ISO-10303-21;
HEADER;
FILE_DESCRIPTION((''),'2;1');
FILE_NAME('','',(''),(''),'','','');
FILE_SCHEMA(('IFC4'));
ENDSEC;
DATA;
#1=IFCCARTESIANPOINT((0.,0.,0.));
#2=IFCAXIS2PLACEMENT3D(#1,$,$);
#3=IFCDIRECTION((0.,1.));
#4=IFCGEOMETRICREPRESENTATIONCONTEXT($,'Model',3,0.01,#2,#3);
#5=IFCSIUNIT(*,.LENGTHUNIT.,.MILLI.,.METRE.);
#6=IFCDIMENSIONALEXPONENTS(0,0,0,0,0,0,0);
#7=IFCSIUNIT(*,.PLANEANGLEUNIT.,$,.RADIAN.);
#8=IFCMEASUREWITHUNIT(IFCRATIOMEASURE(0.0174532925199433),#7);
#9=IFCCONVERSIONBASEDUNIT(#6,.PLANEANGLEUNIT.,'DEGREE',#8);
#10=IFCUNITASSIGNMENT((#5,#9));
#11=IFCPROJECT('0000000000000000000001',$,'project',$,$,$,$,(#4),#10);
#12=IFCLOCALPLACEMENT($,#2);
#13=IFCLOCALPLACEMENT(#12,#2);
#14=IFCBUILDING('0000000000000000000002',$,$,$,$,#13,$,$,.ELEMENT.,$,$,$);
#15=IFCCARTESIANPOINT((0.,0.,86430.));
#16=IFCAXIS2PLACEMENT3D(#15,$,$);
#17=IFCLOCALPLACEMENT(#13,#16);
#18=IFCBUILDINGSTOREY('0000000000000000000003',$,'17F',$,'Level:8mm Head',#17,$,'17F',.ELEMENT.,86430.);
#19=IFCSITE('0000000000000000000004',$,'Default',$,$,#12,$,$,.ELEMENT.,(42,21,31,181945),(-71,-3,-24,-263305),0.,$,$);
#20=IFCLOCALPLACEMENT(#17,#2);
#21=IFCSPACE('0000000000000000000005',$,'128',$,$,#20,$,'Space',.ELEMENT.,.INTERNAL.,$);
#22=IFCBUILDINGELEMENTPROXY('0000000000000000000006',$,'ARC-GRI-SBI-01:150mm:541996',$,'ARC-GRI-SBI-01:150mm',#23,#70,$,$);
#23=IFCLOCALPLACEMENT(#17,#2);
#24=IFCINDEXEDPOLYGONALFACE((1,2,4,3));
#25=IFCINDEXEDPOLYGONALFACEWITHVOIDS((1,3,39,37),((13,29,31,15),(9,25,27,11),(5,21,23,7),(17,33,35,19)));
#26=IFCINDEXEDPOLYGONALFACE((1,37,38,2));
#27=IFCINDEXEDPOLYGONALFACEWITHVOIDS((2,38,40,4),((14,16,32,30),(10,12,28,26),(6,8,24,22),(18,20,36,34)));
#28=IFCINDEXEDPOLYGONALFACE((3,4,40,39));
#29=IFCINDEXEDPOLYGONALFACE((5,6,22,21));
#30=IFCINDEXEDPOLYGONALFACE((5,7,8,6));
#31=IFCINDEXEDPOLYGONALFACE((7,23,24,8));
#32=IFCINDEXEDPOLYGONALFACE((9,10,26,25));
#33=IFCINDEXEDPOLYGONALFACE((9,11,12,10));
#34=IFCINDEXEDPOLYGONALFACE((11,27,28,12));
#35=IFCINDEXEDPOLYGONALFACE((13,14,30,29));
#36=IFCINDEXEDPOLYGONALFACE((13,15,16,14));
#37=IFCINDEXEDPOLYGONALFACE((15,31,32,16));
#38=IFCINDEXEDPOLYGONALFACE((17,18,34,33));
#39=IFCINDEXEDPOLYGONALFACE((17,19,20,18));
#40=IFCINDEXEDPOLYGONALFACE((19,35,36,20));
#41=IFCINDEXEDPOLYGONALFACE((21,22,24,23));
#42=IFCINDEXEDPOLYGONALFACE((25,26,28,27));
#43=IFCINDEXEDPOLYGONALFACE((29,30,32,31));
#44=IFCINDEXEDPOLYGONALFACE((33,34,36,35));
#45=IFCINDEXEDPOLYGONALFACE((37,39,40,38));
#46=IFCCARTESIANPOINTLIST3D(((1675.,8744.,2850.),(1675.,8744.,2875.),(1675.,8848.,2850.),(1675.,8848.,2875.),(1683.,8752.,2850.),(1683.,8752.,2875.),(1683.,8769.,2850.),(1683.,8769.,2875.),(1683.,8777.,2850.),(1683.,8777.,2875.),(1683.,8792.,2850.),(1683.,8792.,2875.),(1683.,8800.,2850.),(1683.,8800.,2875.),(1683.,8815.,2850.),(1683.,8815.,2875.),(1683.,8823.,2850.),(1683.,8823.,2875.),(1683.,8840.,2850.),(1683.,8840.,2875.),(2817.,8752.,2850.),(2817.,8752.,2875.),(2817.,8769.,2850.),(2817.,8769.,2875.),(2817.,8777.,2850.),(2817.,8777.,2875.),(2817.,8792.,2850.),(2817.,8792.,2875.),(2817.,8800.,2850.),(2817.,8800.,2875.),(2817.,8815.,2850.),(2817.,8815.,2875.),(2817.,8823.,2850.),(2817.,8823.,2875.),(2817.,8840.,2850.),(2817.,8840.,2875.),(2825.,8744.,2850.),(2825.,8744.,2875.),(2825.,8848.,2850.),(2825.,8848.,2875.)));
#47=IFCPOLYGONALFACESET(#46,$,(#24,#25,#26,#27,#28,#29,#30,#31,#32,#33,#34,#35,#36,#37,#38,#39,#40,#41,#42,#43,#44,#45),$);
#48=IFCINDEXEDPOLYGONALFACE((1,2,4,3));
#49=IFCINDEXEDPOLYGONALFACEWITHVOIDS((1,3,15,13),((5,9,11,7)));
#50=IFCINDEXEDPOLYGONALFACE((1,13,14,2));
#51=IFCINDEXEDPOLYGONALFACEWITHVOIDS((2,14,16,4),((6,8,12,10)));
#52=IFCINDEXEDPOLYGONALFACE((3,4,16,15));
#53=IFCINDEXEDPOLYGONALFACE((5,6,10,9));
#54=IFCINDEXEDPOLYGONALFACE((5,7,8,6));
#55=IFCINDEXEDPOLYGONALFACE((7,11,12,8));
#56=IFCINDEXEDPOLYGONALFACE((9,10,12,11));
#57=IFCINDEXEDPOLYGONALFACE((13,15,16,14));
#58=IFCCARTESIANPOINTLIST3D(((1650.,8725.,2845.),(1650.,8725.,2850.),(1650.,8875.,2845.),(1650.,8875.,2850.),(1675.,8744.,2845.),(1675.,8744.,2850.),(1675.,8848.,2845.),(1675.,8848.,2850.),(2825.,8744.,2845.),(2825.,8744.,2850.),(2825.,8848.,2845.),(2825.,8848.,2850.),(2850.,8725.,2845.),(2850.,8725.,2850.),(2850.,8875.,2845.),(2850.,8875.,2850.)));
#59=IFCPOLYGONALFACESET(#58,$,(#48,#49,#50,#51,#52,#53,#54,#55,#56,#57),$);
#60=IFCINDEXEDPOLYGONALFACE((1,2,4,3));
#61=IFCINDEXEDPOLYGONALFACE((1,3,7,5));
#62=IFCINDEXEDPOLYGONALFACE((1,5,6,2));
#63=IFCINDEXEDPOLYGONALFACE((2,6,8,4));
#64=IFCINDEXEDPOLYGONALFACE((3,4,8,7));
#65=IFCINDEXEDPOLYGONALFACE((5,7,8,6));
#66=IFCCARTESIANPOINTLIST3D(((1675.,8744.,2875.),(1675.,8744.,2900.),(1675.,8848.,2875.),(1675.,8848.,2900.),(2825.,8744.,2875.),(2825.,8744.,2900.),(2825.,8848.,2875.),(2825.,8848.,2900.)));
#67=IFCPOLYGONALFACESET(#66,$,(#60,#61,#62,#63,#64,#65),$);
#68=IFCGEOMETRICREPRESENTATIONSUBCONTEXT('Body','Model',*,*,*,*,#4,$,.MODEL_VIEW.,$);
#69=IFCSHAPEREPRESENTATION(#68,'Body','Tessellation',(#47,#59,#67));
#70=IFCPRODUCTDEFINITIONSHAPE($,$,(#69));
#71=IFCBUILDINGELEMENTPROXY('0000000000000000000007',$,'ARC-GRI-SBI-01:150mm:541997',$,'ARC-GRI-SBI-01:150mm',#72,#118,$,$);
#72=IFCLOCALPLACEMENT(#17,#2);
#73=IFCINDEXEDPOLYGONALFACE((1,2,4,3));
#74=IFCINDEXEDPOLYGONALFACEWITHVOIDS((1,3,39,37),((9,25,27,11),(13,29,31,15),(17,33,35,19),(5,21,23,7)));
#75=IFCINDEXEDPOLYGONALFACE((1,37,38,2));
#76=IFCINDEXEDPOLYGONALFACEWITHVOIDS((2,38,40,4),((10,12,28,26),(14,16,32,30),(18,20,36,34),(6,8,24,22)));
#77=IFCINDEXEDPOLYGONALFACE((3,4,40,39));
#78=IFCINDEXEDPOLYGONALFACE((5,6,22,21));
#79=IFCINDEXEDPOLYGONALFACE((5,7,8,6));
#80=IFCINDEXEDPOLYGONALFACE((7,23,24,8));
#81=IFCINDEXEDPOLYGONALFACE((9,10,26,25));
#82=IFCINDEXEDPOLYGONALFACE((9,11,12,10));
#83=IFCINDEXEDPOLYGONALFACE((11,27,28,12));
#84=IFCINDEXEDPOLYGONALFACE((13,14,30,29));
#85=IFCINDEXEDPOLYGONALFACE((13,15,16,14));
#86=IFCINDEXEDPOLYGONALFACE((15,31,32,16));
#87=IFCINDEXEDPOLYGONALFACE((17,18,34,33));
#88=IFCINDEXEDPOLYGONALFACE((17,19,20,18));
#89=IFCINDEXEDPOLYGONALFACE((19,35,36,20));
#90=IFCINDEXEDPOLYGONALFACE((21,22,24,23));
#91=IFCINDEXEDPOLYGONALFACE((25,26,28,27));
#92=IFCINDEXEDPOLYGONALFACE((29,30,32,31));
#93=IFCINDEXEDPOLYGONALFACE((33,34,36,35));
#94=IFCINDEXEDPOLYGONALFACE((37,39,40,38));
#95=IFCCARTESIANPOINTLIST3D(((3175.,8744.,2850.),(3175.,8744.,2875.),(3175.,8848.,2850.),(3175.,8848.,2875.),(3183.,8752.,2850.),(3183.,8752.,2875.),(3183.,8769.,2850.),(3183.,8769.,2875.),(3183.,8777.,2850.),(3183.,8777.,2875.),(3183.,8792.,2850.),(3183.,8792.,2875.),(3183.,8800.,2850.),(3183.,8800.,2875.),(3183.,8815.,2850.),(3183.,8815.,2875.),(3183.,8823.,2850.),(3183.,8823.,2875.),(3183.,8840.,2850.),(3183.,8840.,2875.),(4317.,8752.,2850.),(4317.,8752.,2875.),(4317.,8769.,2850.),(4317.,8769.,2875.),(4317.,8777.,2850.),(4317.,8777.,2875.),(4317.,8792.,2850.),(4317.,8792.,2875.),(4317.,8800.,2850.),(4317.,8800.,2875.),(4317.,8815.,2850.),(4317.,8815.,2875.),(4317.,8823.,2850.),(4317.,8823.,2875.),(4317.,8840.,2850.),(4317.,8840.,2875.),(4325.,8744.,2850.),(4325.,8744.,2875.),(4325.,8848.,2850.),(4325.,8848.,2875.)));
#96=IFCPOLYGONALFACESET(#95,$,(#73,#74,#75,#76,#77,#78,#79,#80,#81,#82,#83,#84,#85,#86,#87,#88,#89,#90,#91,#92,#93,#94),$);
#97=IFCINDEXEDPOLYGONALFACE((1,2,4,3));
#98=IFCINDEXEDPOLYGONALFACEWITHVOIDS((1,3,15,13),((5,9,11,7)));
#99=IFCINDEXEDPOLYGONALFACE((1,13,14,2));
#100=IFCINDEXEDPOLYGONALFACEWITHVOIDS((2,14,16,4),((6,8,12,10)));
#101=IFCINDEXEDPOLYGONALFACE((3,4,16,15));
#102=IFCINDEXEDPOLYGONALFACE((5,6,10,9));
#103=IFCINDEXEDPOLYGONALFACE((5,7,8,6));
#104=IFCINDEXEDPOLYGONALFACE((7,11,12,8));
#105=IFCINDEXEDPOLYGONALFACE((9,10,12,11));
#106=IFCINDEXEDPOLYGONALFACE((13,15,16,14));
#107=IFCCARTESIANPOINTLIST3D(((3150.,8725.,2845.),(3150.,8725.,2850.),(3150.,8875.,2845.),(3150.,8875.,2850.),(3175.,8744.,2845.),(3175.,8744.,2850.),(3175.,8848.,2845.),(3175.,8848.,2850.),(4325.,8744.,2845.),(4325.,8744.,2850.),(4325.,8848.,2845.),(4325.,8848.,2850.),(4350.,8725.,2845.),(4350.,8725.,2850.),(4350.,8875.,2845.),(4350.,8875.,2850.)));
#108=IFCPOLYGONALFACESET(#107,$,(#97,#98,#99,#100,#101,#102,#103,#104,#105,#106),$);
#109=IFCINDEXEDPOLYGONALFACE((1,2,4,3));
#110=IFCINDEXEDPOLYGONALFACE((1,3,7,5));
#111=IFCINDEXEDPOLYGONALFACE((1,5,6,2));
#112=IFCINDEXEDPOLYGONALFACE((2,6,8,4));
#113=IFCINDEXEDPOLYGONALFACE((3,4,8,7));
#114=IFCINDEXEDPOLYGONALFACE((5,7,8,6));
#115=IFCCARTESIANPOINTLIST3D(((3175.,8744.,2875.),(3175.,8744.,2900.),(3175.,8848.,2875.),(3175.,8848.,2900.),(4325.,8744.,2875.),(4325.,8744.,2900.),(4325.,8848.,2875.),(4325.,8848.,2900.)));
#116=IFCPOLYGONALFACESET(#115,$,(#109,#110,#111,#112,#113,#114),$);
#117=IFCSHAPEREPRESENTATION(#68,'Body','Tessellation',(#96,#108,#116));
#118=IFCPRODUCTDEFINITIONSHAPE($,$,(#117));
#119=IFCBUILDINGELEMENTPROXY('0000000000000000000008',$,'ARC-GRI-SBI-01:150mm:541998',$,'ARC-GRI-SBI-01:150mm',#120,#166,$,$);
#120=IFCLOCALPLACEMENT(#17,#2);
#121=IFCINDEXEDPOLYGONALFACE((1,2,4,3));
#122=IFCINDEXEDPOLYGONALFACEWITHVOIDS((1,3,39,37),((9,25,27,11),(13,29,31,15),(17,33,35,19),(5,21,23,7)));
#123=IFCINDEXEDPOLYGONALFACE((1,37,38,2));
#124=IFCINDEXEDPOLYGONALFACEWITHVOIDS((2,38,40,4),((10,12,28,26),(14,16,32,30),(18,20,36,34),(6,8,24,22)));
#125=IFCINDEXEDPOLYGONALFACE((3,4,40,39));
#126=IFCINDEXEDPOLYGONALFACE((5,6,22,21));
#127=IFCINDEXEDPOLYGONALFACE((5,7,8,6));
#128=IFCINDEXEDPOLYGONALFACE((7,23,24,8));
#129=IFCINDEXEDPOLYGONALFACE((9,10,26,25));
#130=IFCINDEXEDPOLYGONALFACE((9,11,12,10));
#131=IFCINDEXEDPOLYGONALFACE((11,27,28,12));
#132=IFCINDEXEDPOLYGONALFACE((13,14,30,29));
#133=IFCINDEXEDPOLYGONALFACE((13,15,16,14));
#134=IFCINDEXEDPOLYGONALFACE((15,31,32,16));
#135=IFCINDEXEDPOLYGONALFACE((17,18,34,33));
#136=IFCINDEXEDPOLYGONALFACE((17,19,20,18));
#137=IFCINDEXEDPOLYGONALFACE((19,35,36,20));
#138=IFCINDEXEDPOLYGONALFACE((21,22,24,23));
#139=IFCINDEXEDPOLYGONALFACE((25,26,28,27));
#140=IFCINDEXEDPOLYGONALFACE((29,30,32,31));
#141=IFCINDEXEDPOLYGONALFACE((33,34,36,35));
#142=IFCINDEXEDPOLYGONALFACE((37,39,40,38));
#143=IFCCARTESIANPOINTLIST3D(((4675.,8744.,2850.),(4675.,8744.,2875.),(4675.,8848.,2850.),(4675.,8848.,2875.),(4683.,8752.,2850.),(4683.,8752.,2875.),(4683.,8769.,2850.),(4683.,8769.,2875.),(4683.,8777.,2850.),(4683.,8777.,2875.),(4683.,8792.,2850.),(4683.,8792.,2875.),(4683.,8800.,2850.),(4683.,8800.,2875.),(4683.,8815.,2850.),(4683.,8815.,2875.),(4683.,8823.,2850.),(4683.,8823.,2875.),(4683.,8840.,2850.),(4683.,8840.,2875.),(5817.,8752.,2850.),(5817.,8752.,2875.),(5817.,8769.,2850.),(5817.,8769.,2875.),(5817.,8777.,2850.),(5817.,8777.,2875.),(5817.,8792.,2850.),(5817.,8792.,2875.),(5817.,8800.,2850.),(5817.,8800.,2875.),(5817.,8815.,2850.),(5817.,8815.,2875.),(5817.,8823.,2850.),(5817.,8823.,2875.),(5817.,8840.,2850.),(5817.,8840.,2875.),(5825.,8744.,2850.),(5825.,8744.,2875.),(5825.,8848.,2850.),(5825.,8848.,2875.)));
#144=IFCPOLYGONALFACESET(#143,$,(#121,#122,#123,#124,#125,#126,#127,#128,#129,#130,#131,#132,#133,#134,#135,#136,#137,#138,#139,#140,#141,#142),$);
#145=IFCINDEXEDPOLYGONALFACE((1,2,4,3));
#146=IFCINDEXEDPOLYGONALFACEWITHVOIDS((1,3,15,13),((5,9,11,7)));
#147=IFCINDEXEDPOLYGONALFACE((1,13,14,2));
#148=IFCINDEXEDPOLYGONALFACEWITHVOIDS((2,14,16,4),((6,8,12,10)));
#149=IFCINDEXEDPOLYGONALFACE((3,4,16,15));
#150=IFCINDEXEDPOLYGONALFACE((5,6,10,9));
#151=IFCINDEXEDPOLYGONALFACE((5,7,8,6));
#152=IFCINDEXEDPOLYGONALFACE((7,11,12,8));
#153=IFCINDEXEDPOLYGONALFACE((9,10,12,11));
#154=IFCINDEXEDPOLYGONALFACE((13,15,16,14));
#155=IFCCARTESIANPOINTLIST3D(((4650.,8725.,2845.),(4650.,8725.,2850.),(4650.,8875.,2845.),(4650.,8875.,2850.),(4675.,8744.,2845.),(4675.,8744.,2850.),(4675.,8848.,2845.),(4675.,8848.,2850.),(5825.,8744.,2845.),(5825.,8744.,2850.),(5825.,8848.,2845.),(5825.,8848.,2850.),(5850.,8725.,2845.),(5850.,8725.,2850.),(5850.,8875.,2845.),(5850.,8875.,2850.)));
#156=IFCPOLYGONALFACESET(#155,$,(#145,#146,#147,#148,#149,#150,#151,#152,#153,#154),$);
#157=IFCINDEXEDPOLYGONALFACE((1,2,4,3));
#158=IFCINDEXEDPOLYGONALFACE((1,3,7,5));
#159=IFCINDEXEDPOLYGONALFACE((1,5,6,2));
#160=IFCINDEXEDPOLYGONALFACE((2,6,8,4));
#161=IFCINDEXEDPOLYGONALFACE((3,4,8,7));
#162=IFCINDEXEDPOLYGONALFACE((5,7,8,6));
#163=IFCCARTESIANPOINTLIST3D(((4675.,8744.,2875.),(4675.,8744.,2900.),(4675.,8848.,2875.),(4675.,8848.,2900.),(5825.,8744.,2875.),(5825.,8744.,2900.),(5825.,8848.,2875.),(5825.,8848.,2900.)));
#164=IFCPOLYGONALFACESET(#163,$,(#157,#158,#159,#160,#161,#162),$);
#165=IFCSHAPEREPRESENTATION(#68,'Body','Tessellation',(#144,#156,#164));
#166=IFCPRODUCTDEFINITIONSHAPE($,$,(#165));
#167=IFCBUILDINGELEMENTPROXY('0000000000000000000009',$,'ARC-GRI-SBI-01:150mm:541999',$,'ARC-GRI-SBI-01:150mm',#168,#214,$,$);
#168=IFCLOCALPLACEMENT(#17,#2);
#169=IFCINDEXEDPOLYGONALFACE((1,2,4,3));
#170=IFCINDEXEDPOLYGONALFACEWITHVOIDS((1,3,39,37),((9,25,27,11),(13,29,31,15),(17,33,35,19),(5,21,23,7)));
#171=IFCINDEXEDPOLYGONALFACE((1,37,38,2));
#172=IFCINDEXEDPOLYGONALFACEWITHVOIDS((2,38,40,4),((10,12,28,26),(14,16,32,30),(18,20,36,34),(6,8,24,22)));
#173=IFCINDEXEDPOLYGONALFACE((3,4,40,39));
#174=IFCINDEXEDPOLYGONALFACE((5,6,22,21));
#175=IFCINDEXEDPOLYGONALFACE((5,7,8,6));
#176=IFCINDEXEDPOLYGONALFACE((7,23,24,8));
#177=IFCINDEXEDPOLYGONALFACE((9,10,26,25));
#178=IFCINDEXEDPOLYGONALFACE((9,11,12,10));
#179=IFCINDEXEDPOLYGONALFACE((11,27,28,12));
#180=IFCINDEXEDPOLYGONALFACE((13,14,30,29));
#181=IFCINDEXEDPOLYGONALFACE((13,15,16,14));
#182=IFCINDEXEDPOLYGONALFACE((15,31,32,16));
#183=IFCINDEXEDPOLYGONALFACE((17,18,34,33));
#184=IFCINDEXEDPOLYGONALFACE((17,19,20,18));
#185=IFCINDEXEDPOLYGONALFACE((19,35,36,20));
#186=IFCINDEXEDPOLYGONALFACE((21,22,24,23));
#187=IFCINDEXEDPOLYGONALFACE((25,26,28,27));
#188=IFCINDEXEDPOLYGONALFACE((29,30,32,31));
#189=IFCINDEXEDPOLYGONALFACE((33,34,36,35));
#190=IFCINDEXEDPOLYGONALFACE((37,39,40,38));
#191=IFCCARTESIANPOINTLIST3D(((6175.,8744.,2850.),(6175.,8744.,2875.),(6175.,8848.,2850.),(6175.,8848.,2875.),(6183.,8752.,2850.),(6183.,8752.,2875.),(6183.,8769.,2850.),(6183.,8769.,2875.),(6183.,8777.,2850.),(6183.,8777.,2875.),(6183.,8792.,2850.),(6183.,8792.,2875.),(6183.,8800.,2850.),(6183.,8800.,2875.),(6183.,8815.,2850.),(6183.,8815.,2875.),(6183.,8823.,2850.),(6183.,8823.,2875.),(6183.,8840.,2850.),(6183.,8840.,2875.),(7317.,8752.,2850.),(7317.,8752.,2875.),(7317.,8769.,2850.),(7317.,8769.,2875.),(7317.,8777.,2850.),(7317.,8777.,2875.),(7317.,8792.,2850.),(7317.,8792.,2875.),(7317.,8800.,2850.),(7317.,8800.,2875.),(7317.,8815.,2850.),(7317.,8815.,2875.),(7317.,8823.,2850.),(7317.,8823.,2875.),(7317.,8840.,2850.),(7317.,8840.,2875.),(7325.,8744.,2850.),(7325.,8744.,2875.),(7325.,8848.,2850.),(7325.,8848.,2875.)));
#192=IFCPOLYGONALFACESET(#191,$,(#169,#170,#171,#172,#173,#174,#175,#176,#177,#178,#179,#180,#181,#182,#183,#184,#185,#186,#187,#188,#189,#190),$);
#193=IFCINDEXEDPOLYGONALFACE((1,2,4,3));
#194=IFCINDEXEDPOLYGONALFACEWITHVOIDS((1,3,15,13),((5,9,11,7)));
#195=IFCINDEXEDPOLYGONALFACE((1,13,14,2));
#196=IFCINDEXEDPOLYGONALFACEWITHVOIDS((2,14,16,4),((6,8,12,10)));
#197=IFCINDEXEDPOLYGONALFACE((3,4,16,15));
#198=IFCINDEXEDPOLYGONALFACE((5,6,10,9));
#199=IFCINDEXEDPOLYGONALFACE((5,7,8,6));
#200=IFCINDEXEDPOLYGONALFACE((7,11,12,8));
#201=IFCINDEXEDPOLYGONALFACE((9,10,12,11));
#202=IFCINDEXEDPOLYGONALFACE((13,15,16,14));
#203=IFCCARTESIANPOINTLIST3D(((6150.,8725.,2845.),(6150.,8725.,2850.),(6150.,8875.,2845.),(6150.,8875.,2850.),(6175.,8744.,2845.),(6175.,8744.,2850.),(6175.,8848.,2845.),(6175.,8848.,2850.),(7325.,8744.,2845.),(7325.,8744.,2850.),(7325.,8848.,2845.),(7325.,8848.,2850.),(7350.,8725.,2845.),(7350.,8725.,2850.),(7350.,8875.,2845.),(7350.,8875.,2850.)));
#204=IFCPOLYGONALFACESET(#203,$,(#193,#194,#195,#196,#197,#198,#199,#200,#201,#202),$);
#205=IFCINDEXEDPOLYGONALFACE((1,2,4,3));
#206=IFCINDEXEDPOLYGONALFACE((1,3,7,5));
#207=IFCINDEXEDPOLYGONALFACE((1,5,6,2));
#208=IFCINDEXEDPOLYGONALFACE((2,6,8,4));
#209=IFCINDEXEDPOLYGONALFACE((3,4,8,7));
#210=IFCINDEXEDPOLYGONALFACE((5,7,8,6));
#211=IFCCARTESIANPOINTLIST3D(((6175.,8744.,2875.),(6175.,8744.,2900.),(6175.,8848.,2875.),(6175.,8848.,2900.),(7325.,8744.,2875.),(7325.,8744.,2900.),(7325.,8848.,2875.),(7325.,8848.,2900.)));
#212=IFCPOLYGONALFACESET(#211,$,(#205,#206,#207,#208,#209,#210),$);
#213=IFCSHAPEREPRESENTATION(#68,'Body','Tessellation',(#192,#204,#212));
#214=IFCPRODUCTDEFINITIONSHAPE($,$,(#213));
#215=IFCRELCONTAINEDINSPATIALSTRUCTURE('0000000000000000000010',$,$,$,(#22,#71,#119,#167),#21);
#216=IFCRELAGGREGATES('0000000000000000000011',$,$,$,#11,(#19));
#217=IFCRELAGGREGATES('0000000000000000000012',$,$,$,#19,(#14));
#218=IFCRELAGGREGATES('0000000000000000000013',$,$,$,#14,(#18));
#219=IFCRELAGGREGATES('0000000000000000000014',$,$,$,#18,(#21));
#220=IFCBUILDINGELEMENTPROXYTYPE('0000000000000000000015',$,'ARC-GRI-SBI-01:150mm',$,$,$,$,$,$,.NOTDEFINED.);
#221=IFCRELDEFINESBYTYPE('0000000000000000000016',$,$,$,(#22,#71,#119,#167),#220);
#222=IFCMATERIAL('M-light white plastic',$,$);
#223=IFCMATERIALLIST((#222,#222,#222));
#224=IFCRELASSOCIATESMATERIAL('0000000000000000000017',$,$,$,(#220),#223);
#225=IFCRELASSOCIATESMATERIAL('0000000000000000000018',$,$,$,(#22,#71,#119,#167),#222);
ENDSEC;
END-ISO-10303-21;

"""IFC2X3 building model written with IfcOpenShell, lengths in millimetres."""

from ifc_helpers import new_model, entity, si_unit, converted_unit, direction, frame, origin, origin_2d_with_axis, place, context, subcontext, project, spatial, polyline, rectangle, outline, extrude, source, transform, mapped, material, material_list, type_object, type_shapes, element, save


model = new_model("IFC2X3")

# Units and contexts
model_context = context("Model", 3, precision=0.01, world=origin(), true_north=direction((0.0, 1.0)))
body_context = subcontext(model_context, "Body", "Model", "MODEL_VIEW")
ifc_project = project(units=[si_unit("LENGTHUNIT", "METRE", prefix="MILLI"), converted_unit("PLANEANGLEUNIT", "DEGREE", entity("IfcRatioMeasure", 0.0174532925199433), si_unit("PLANEANGLEUNIT", "RADIAN"), dimensions=[0, 0, 0, 0, 0, 0, 0])], contexts=[model_context])

# Site, building, storey
site_placement = place(None, origin())
site = spatial("IfcSite", under=ifc_project, at=site_placement, Name="Default", CompositionType="ELEMENT", RefLatitude=(42, 21, 31, 181945), RefLongitude=(-71, -3, -24, -263305), RefElevation=0.0)
building_placement = place(site_placement, origin())
building = spatial("IfcBuilding", under=site, at=building_placement, CompositionType="ELEMENT")
storey_placement = place(building_placement, frame((0.0, 0.0, 86430.0)))
storey = spatial("IfcBuildingStorey", under=building, at=storey_placement, Name="17F", ObjectType="Level:8mm Head", LongName="17F", CompositionType="ELEMENT", Elevation=86430.0)

# Shared definitions
space_placement = place(storey_placement, origin())
space = spatial("IfcSpace", under=storey, at=space_placement, Name="128", LongName="Space", CompositionType="ELEMENT", InteriorOrExteriorSpace="INTERNAL")

# Building element proxies
ifc_material_1 = material(Name="M-light white plastic")
ifc_material_list = material_list([ifc_material_1, ifc_material_1, ifc_material_1])
building_element_proxy_type = type_object("IfcBuildingElementProxyType", Name="ARC-GRI-SBI-01:150mm", PredefinedType="NOTDEFINED", material=ifc_material_list)
shared_shape = source(origin(), body_context, "Body", "SweptSolid", [
    extrude(outline(polyline([(-575.0, -52.0), (575.0, -52.0), (575.0, 52.0), (-575.0, 52.0), (-575.0, -52.0)]), holes=[polyline([(-567.0, -44.0), (-567.0, -27.0), (567.0, -27.0), (567.0, -44.0), (-567.0, -44.0)]), polyline([(567.0, -4.0), (567.0, -19.0), (-567.0, -19.0), (-567.0, -4.0), (567.0, -4.0)]), polyline([(-567.0, 44.0), (567.0, 44.0), (567.0, 27.0), (-567.0, 27.0), (-567.0, 44.0)]), polyline([(567.0, 4.0), (-567.0, 4.0), (-567.0, 19.0), (567.0, 19.0), (567.0, 4.0)])]), frame((425.0, 4.0, 4000.0), z_axis=(0.0, 0.0, 1.0), x_axis=(-1.0, 0.0, 0.0)), (0.0, 0.0, 1.0), 25.0),
    extrude(outline(polyline([(-600.0, -75.0), (600.0, -75.0), (600.0, 75.0), (-600.0, 75.0), (-600.0, -75.0)]), holes=[polyline([(-575.0, -56.0), (-575.0, 48.0), (575.0, 48.0), (575.0, -56.0), (-575.0, -56.0)])]), frame((425.0, 0.0, 3995.0), z_axis=(0.0, 0.0, 1.0), x_axis=(-1.0, 0.0, 0.0)), (0.0, 0.0, 1.0), 5.0),
    extrude(rectangle(XDim=1150.0, YDim=104.0, at=origin_2d_with_axis()), frame((425.0, 4.0, 4025.0), z_axis=(0.0, 0.0, 1.0), x_axis=(-1.0, 0.0, 0.0)), (0.0, 0.0, 1.0), 25.0),
])
type_shapes(building_element_proxy_type, [shared_shape])
for number, where, z_axis, x_axis, name in (
    (1, (2675.0, 8800.0, -1150.0), (0.0, 0.0, 1.0), (-1.0, 0.0, 0.0), "ARC-GRI-SBI-01:150mm:541996"),
    (2, (4175.0, 8800.0, -1150.0), (0.0, 0.0, 1.0), (-1.0, 0.0, 0.0), "ARC-GRI-SBI-01:150mm:541997"),
    (3, (5675.0, 8800.0, -1150.0), (0.0, 0.0, 1.0), (-1.0, 0.0, 0.0), "ARC-GRI-SBI-01:150mm:541998"),
    (4, (7175.0, 8800.0, -1150.0), (0.0, 0.0, 1.0), (-1.0, 0.0, 0.0), "ARC-GRI-SBI-01:150mm:541999"),
):
    element("IfcBuildingElementProxy", number, at=place(space_placement, frame(where, z_axis=z_axis, x_axis=x_axis)), inside=space, type_object=building_element_proxy_type, material=ifc_material_1, Name=name, ObjectType="ARC-GRI-SBI-01:150mm", context=body_context, shape_type="MappedRepresentation", body=[
        mapped(shared_shape, transform((0.0, 0.0, 0.0), scale=1.0)),
    ])

save(model, "model.ifc")
